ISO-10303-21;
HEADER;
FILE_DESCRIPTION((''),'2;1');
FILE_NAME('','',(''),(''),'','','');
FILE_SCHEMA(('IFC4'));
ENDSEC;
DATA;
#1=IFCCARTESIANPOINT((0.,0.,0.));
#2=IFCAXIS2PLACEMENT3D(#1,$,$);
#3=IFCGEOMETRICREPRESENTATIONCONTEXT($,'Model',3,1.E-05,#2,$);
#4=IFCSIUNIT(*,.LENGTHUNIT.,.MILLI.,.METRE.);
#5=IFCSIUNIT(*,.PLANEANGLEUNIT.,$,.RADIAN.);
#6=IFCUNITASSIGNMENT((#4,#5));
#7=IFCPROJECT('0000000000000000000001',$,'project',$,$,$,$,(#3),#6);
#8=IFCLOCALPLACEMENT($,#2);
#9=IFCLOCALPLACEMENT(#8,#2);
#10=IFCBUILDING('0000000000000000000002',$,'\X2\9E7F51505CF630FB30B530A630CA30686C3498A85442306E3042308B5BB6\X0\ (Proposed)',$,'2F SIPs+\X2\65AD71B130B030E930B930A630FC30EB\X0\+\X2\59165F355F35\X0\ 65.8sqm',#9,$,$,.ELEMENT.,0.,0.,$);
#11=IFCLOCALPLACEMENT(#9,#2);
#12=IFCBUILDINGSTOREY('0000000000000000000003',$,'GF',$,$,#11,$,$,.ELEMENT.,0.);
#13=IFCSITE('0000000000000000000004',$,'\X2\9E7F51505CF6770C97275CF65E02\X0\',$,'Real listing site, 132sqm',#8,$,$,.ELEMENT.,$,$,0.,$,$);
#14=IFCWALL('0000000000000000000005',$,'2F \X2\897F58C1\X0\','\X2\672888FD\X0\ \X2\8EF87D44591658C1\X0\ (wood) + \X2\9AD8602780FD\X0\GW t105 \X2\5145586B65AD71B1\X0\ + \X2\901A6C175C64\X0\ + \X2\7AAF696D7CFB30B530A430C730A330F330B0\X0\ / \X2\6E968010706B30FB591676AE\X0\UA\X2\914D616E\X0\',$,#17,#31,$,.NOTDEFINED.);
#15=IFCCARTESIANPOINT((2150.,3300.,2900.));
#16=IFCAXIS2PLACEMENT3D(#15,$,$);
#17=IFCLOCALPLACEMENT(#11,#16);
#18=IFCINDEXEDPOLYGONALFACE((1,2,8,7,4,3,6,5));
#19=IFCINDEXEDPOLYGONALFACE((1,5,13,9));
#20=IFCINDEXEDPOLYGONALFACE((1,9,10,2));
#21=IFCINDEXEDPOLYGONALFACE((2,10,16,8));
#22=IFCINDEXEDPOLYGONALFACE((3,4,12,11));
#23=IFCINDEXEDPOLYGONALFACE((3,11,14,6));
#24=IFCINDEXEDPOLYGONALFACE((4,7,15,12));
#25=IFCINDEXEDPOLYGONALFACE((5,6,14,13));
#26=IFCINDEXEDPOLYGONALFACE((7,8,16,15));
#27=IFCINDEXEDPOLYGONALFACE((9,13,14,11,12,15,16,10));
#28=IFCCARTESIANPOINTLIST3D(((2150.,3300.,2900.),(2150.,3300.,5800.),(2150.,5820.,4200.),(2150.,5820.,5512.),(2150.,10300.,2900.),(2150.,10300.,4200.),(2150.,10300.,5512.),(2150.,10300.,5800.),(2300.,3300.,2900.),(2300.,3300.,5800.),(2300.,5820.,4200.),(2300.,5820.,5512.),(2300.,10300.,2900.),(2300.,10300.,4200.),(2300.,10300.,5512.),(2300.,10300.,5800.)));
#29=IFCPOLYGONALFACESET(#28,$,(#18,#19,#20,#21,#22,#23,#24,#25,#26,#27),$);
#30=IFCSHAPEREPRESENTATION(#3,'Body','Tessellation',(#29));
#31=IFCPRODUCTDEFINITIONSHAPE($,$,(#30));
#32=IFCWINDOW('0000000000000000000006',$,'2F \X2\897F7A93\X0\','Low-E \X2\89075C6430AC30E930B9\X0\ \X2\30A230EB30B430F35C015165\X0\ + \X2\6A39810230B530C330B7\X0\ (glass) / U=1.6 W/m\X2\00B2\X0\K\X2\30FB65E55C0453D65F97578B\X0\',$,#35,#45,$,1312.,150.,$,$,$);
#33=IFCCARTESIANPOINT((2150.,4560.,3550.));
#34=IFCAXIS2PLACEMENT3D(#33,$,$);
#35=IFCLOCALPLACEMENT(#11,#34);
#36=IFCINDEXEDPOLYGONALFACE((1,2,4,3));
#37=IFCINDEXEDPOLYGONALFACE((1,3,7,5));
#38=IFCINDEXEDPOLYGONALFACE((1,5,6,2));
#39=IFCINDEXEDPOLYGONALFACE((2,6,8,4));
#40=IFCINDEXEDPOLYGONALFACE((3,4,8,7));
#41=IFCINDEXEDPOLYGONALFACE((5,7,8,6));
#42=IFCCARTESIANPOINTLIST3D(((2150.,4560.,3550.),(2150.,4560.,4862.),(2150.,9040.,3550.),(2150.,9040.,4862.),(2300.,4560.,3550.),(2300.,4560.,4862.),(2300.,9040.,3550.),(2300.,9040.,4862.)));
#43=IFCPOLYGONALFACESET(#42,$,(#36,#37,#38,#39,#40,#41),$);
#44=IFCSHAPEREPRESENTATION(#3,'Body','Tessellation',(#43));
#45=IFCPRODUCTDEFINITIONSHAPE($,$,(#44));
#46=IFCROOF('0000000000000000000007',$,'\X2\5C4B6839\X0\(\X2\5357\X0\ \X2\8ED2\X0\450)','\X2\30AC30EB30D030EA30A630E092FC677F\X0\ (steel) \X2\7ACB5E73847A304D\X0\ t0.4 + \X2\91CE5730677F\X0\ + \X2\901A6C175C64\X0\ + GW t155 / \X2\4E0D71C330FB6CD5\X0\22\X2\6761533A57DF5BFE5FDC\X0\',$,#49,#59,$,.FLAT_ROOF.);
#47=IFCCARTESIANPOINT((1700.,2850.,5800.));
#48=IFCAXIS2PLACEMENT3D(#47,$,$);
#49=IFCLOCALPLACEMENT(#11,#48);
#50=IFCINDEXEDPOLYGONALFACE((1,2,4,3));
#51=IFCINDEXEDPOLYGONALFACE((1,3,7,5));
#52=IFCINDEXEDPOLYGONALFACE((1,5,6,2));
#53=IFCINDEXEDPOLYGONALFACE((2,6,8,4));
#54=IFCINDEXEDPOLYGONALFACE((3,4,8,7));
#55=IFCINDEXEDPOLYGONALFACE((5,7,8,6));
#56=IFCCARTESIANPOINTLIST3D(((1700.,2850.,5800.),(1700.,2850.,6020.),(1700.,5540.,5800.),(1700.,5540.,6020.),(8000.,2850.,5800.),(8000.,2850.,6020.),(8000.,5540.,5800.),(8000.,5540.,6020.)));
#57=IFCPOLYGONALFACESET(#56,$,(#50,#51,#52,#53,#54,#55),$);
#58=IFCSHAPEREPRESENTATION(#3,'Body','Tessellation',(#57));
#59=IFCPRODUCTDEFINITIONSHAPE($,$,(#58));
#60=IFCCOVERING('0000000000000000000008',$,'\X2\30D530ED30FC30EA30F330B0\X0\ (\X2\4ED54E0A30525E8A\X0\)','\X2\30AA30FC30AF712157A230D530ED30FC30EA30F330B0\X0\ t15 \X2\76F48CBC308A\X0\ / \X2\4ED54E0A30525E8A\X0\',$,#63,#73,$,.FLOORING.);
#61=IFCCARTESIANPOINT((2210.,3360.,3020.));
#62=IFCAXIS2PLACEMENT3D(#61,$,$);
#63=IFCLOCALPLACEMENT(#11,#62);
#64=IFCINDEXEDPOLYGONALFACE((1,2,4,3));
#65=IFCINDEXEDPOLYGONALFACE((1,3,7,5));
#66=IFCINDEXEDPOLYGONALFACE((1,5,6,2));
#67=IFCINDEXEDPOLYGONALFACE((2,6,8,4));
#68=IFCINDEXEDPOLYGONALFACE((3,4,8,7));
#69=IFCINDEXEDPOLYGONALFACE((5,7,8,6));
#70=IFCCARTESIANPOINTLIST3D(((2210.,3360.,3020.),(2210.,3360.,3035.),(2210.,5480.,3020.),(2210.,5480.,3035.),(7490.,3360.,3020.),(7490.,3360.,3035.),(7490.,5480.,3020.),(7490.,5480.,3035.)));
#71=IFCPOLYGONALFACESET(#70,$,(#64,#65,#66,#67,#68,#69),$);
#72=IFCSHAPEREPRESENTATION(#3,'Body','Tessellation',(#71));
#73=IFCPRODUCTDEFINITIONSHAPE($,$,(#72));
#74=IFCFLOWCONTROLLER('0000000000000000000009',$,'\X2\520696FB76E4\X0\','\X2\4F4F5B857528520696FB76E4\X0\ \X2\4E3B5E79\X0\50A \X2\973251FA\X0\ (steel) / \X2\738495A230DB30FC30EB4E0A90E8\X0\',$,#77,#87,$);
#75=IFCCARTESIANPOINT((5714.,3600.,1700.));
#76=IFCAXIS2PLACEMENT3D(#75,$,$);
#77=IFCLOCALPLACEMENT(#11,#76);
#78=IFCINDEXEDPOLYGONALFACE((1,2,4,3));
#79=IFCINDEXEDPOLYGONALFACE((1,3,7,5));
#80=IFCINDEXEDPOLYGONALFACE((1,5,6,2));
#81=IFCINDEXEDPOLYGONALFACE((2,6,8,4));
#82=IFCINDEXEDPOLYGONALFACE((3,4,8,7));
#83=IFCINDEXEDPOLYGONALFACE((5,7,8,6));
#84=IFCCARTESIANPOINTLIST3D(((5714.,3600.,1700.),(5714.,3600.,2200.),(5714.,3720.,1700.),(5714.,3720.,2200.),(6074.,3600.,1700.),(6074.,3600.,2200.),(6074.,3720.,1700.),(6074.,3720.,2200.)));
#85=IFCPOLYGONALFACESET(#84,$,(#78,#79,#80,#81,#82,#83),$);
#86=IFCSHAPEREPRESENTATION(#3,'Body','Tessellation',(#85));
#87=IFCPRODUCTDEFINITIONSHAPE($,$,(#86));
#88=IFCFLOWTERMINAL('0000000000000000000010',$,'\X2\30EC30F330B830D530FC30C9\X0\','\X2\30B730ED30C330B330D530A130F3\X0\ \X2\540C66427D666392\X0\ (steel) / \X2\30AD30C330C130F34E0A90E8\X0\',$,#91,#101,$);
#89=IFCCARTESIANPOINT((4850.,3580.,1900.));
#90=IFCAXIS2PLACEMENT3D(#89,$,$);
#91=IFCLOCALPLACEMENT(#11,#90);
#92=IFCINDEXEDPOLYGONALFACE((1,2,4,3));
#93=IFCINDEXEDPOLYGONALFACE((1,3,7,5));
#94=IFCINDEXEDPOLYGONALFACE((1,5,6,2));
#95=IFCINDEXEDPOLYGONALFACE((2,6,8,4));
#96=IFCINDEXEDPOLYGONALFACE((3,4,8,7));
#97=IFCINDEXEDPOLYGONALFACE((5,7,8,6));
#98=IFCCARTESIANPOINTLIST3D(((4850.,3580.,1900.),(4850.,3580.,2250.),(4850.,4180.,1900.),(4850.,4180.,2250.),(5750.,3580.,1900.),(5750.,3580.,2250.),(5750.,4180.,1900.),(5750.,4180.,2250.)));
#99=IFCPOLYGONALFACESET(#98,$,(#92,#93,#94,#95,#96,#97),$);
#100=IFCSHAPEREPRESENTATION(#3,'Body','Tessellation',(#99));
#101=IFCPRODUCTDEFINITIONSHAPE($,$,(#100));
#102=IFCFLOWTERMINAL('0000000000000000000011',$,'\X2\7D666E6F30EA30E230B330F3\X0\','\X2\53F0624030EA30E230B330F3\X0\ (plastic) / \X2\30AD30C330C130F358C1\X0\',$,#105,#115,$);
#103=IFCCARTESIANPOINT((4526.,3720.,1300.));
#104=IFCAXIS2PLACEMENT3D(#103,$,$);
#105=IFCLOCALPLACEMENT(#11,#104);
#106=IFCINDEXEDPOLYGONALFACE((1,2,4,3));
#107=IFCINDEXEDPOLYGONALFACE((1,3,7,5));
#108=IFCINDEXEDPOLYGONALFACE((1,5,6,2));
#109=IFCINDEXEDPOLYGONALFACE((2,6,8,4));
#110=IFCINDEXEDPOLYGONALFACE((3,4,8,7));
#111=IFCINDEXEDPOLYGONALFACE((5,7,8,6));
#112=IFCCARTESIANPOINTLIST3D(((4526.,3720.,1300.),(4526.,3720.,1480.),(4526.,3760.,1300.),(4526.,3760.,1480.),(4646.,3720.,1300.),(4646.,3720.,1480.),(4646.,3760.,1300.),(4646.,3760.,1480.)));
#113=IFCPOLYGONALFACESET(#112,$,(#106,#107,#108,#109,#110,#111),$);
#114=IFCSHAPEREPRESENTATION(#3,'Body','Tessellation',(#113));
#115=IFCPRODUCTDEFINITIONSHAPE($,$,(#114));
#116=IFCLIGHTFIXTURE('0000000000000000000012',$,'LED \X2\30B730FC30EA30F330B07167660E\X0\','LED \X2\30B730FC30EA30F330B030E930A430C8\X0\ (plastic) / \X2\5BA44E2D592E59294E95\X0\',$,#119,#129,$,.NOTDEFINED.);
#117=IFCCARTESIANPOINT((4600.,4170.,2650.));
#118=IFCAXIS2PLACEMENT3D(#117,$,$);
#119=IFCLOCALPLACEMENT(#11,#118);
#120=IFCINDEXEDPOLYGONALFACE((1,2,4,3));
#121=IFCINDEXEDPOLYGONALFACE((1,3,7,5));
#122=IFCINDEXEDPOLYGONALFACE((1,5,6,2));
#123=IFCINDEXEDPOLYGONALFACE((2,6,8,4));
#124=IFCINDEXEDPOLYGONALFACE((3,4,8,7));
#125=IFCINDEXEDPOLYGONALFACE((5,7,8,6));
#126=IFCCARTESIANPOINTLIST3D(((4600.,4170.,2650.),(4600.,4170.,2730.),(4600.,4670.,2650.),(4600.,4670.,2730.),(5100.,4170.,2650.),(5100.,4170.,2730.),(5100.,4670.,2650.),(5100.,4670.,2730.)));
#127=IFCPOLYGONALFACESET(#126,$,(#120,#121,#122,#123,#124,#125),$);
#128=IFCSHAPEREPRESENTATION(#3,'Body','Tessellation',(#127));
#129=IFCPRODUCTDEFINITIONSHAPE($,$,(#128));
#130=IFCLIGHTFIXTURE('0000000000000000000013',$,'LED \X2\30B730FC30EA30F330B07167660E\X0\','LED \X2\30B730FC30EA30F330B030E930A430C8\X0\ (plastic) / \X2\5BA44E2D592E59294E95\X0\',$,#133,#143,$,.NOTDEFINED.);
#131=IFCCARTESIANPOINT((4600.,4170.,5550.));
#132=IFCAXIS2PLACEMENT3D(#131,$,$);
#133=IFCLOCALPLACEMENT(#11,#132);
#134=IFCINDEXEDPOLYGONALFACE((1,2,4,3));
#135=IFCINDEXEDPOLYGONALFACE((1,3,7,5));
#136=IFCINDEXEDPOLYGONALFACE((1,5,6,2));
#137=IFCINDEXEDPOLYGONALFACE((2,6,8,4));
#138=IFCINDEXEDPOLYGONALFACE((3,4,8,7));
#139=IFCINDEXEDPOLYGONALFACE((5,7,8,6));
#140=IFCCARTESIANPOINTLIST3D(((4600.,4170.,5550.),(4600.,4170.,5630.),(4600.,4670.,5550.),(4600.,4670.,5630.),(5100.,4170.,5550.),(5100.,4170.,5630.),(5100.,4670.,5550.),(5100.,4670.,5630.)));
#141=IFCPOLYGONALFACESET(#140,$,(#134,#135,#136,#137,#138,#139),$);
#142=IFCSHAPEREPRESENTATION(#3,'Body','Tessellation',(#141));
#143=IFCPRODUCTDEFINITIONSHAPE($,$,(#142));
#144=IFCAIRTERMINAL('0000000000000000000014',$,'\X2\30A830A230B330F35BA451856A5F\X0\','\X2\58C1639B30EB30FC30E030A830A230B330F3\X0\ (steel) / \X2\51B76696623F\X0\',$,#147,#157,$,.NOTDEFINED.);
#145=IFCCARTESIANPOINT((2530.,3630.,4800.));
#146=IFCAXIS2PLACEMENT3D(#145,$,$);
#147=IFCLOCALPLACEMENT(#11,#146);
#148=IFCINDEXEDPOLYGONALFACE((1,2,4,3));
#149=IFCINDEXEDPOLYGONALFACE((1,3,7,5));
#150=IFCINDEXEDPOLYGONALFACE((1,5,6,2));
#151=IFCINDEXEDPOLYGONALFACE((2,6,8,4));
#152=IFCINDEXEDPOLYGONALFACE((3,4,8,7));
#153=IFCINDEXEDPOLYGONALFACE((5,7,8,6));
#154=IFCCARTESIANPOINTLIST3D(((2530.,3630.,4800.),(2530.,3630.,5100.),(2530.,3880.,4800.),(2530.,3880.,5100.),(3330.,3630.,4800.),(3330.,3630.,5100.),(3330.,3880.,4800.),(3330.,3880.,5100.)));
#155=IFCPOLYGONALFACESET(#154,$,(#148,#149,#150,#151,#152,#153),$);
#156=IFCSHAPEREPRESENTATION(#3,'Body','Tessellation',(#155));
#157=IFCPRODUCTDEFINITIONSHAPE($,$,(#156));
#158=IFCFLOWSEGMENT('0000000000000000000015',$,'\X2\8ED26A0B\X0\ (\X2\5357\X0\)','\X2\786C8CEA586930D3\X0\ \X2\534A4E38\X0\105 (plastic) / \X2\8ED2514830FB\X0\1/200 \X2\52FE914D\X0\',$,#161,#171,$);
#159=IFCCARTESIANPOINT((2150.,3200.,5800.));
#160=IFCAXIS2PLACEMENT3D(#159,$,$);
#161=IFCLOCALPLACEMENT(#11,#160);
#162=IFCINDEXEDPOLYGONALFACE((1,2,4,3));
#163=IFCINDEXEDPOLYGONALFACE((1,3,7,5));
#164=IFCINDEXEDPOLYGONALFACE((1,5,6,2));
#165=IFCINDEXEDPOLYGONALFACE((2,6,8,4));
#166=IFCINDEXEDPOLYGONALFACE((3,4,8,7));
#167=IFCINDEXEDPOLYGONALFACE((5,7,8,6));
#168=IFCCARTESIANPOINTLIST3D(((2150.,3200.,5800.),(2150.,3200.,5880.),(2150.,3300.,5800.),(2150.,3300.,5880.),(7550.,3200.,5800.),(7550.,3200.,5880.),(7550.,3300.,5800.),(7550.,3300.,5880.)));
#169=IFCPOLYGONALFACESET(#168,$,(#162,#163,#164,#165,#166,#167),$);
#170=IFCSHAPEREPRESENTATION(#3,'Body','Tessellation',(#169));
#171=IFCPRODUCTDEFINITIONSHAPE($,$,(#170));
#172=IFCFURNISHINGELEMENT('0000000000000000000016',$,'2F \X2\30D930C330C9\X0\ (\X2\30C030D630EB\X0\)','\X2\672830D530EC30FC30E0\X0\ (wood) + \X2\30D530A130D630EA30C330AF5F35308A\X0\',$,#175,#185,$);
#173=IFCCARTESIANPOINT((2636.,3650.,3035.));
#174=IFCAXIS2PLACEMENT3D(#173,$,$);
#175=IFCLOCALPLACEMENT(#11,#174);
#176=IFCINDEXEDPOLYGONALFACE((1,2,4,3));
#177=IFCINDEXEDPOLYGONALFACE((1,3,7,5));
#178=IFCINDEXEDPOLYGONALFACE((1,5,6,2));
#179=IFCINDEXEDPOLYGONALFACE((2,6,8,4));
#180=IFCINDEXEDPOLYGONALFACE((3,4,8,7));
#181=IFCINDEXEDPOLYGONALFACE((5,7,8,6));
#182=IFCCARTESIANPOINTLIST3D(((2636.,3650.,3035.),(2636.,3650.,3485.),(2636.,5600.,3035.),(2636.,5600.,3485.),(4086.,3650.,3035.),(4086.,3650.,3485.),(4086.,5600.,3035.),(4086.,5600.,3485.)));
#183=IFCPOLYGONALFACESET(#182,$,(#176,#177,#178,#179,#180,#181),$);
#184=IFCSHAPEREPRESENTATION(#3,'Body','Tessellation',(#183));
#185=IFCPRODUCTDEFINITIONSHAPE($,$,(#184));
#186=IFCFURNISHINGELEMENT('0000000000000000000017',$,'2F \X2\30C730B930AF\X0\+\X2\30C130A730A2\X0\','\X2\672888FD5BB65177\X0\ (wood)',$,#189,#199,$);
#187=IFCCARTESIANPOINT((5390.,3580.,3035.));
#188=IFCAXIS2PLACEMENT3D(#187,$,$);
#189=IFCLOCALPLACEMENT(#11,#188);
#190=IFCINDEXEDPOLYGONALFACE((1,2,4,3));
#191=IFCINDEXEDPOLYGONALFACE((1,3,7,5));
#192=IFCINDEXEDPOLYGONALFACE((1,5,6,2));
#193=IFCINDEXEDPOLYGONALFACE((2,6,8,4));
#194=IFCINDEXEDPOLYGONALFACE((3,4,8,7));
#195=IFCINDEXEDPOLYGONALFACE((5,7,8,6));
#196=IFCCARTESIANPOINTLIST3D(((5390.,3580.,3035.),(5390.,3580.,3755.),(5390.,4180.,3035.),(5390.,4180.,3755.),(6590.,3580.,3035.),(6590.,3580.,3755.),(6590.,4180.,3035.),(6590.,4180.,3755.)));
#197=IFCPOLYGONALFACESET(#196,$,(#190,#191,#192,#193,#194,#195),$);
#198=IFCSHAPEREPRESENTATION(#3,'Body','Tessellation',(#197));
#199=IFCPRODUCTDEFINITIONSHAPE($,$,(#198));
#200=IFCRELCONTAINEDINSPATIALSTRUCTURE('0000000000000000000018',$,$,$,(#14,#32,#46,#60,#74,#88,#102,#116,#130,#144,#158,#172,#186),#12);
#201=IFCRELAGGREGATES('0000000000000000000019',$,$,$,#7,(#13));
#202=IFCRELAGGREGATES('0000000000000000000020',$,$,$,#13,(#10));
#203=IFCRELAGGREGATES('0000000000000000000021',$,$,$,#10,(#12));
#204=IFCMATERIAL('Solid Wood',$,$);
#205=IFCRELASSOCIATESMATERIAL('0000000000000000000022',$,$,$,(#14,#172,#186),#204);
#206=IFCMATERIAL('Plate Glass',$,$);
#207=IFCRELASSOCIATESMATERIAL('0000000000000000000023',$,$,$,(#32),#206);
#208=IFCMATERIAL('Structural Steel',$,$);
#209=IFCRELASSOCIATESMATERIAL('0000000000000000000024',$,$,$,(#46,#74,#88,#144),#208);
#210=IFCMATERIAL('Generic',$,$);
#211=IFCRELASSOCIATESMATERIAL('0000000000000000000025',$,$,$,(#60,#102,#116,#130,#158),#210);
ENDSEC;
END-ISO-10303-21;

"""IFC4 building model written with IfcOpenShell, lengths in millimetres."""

from ifc_helpers import new_model, si_unit, frame, frame_2d, origin, place, context, project, spatial, rectangle, extrude, material, element, fill, save


model = new_model("IFC4")

# Units and contexts
model_context = context("Model", 3, precision=1e-05, world=origin())
ifc_project = project(units=[si_unit("LENGTHUNIT", "METRE", prefix="MILLI"), si_unit("PLANEANGLEUNIT", "RADIAN")], contexts=[model_context])

# Site, building, storey
site_placement = place(None, origin())
site = spatial("IfcSite", under=ifc_project, at=site_placement, Name="鹿児島県霧島市", ObjectType="Real listing site, 132sqm", CompositionType="ELEMENT", RefElevation=0.0)
building_placement = place(site_placement, origin())
building = spatial("IfcBuilding", under=site, at=building_placement, Name="鹿児島・サウナと水風呂のある家 (Proposed)", ObjectType="2F SIPs+断熱グラスウール+外張張 65.8sqm", CompositionType="ELEMENT", ElevationOfRefHeight=0.0, ElevationOfTerrain=0.0)
storey_placement = place(building_placement, origin())
storey = spatial("IfcBuildingStorey", under=building, at=storey_placement, Name="GF", CompositionType="ELEMENT", Elevation=0.0)

# Shared definitions
ifc_material_1 = material(Name="Solid Wood")

# Wall, opening, window
ifc_material_2 = material(Name="Plate Glass")
wall_1_placement = place(storey_placement, frame((2150.0, 3300.0, 2900.0)))
wall_1 = element("IfcWall", 1, at=wall_1_placement, inside=storey, material=ifc_material_1, Name="2F 西壁", Description="木製 軸組外壁 (wood) + 高性能GW t105 充填断熱 + 通気層 + 窯業系サイディング / 準耐火・外皮UA配慮", PredefinedType="NOTDEFINED", context=model_context, shape_type="SweptSolid", body=[
    extrude(rectangle(XDim=150.0, YDim=7000.0, at=frame_2d((75.0, 3500.0))), frame((2150.0, 3300.0, 2900.0)), (0.0, 0.0, 1.0), 2900.0),
])
opening_1_placement = place(storey_placement, frame((2150.0, 4560.0, 3550.0)))
opening_1 = element("IfcOpeningElement", 2, at=opening_1_placement, cuts=wall_1, PredefinedType="NOTDEFINED", context=model_context, shape_type="SweptSolid", body=[
    extrude(rectangle(XDim=150.0, YDim=4480.0, at=frame_2d((75.0, 2240.0))), frame((2150.0, 4560.0, 3550.0)), (0.0, 0.0, 1.0), 1312.0),
])
window_1_placement = place(storey_placement, frame((2150.0, 4560.0, 3550.0)))
window_1 = element("IfcWindow", 3, at=window_1_placement, inside=storey, material=ifc_material_2, Name="2F 西窓", Description="Low-E 複層ガラス アルゴン封入 + 樹脂サッシ (glass) / U=1.6 W/m²K・日射取得型", OverallHeight=1312.0, OverallWidth=150.0, context=model_context, shape_type="SweptSolid", body=[
    extrude(rectangle(XDim=150.0, YDim=4480.0, at=frame_2d((75.0, 2240.0))), frame((2150.0, 4560.0, 3550.0)), (0.0, 0.0, 1.0), 1312.0),
])
fill(opening_1, window_1)

# Roof
ifc_material_3 = material(Name="Structural Steel")
for number, where, name in (
    (4, (1700.0, 2850.0, 5800.0), "屋根(南 軒450)"),
):
    element("IfcRoof", number, at=place(storey_placement, frame(where)), inside=storey, material=ifc_material_3, Name=name, Description="ガルバリウム鋼板 (steel) 立平葺き t0.4 + 野地板 + 通気層 + GW t155 / 不燃・法22条区域対応", PredefinedType="FLAT_ROOF", context=model_context, shape_type="SweptSolid", body=[
        extrude(rectangle(XDim=6300.0, YDim=2690.0, at=frame_2d((3150.0, 1345.0))), frame((1700.0, 2850.0, 5800.0)), (0.0, 0.0, 1.0), 220.0),
    ])

# Covering
ifc_material_4 = material(Name="Generic")
covering_placement = place(storey_placement, frame((2210.0, 3360.0, 3020.0)))
element("IfcCovering", 5, at=covering_placement, inside=storey, material=ifc_material_4, Name="フローリング (仕上げ床)", Description="オーク無垢フローリング t15 直貼り / 仕上げ床", PredefinedType="FLOORING", context=model_context, shape_type="SweptSolid", body=[
    extrude(rectangle(XDim=5280.0, YDim=2120.0, at=frame_2d((2640.0, 1060.0))), frame((2210.0, 3360.0, 3020.0)), (0.0, 0.0, 1.0), 15.0),
])

# Flow controller
flow_controller_placement = place(storey_placement, frame((5714.0, 3600.0, 1700.0)))
element("IfcFlowController", 6, at=flow_controller_placement, inside=storey, material=ifc_material_3, Name="分電盤", Description="住宅用分電盤 主幹50A 露出 (steel) / 玄関ホール上部", context=model_context, shape_type="SweptSolid", body=[
    extrude(rectangle(XDim=360.0, YDim=120.0, at=frame_2d((180.0, 60.0))), frame((5714.0, 3600.0, 1700.0)), (0.0, 0.0, 1.0), 500.0),
])

# Flow terminals
flow_terminal_1_placement = place(storey_placement, frame((4850.0, 3580.0, 1900.0)))
element("IfcFlowTerminal", 7, at=flow_terminal_1_placement, inside=storey, material=ifc_material_3, Name="レンジフード", Description="シロッコファン 同時給排 (steel) / キッチン上部", context=model_context, shape_type="SweptSolid", body=[
    extrude(rectangle(XDim=900.0, YDim=600.0, at=frame_2d((450.0, 300.0))), frame((4850.0, 3580.0, 1900.0)), (0.0, 0.0, 1.0), 350.0),
])
flow_terminal_2_placement = place(storey_placement, frame((4526.0, 3720.0, 1300.0)))
element("IfcFlowTerminal", 8, at=flow_terminal_2_placement, inside=storey, material=ifc_material_4, Name="給湯リモコン", Description="台所リモコン (plastic) / キッチン壁", context=model_context, shape_type="SweptSolid", body=[
    extrude(rectangle(XDim=120.0, YDim=40.0, at=frame_2d((60.0, 20.0))), frame((4526.0, 3720.0, 1300.0)), (0.0, 0.0, 1.0), 180.0),
])

# Light fixtures
light_fixture_1_placement = place(storey_placement, frame((4600.0, 4170.0, 2650.0)))
element("IfcLightFixture", 9, at=light_fixture_1_placement, inside=storey, material=ifc_material_4, Name="LED シーリング照明", Description="LED シーリングライト (plastic) / 室中央天井", PredefinedType="NOTDEFINED", context=model_context, shape_type="SweptSolid", body=[
    extrude(rectangle(XDim=500.0, YDim=500.0, at=frame_2d((250.0, 250.0))), frame((4600.0, 4170.0, 2650.0)), (0.0, 0.0, 1.0), 80.0),
])
light_fixture_2_placement = place(storey_placement, frame((4600.0, 4170.0, 5550.0)))
element("IfcLightFixture", 10, at=light_fixture_2_placement, inside=storey, material=ifc_material_4, Name="LED シーリング照明", Description="LED シーリングライト (plastic) / 室中央天井", PredefinedType="NOTDEFINED", context=model_context, shape_type="SweptSolid", body=[
    extrude(rectangle(XDim=500.0, YDim=500.0, at=frame_2d((250.0, 250.0))), frame((4600.0, 4170.0, 5550.0)), (0.0, 0.0, 1.0), 80.0),
])

# Air terminal
air_terminal_placement = place(storey_placement, frame((2530.0, 3630.0, 4800.0)))
element("IfcAirTerminal", 11, at=air_terminal_placement, inside=storey, material=ifc_material_3, Name="エアコン室内機", Description="壁掛ルームエアコン (steel) / 冷暖房", PredefinedType="NOTDEFINED", context=model_context, shape_type="SweptSolid", body=[
    extrude(rectangle(XDim=800.0, YDim=250.0, at=frame_2d((400.0, 125.0))), frame((2530.0, 3630.0, 4800.0)), (0.0, 0.0, 1.0), 300.0),
])

# Flow segment
flow_segment_placement = place(storey_placement, frame((2150.0, 3200.0, 5800.0)))
element("IfcFlowSegment", 12, at=flow_segment_placement, inside=storey, material=ifc_material_4, Name="軒樋 (南)", Description="硬質塩ビ 半丸105 (plastic) / 軒先・1/200 勾配", context=model_context, shape_type="SweptSolid", body=[
    extrude(rectangle(XDim=5400.0, YDim=100.0, at=frame_2d((2700.0, 50.0))), frame((2150.0, 3200.0, 5800.0)), (0.0, 0.0, 1.0), 80.0),
])

# Furnishing elements
furnishing_1_placement = place(storey_placement, frame((2636.0, 3650.0, 3035.0)))
element("IfcFurnishingElement", 13, at=furnishing_1_placement, inside=storey, material=ifc_material_1, Name="2F ベッド (ダブル)", Description="木フレーム (wood) + ファブリック張り", context=model_context, shape_type="SweptSolid", body=[
    extrude(rectangle(XDim=1450.0, YDim=1950.0, at=frame_2d((725.0, 975.0))), frame((2636.0, 3650.0, 3035.0)), (0.0, 0.0, 1.0), 450.0),
])
furnishing_2_placement = place(storey_placement, frame((5390.0, 3580.0, 3035.0)))
element("IfcFurnishingElement", 14, at=furnishing_2_placement, inside=storey, material=ifc_material_1, Name="2F デスク+チェア", Description="木製家具 (wood)", context=model_context, shape_type="SweptSolid", body=[
    extrude(rectangle(XDim=1200.0, YDim=600.0, at=frame_2d((600.0, 300.0))), frame((5390.0, 3580.0, 3035.0)), (0.0, 0.0, 1.0), 720.0),
])

save(model, "model.ifc")
